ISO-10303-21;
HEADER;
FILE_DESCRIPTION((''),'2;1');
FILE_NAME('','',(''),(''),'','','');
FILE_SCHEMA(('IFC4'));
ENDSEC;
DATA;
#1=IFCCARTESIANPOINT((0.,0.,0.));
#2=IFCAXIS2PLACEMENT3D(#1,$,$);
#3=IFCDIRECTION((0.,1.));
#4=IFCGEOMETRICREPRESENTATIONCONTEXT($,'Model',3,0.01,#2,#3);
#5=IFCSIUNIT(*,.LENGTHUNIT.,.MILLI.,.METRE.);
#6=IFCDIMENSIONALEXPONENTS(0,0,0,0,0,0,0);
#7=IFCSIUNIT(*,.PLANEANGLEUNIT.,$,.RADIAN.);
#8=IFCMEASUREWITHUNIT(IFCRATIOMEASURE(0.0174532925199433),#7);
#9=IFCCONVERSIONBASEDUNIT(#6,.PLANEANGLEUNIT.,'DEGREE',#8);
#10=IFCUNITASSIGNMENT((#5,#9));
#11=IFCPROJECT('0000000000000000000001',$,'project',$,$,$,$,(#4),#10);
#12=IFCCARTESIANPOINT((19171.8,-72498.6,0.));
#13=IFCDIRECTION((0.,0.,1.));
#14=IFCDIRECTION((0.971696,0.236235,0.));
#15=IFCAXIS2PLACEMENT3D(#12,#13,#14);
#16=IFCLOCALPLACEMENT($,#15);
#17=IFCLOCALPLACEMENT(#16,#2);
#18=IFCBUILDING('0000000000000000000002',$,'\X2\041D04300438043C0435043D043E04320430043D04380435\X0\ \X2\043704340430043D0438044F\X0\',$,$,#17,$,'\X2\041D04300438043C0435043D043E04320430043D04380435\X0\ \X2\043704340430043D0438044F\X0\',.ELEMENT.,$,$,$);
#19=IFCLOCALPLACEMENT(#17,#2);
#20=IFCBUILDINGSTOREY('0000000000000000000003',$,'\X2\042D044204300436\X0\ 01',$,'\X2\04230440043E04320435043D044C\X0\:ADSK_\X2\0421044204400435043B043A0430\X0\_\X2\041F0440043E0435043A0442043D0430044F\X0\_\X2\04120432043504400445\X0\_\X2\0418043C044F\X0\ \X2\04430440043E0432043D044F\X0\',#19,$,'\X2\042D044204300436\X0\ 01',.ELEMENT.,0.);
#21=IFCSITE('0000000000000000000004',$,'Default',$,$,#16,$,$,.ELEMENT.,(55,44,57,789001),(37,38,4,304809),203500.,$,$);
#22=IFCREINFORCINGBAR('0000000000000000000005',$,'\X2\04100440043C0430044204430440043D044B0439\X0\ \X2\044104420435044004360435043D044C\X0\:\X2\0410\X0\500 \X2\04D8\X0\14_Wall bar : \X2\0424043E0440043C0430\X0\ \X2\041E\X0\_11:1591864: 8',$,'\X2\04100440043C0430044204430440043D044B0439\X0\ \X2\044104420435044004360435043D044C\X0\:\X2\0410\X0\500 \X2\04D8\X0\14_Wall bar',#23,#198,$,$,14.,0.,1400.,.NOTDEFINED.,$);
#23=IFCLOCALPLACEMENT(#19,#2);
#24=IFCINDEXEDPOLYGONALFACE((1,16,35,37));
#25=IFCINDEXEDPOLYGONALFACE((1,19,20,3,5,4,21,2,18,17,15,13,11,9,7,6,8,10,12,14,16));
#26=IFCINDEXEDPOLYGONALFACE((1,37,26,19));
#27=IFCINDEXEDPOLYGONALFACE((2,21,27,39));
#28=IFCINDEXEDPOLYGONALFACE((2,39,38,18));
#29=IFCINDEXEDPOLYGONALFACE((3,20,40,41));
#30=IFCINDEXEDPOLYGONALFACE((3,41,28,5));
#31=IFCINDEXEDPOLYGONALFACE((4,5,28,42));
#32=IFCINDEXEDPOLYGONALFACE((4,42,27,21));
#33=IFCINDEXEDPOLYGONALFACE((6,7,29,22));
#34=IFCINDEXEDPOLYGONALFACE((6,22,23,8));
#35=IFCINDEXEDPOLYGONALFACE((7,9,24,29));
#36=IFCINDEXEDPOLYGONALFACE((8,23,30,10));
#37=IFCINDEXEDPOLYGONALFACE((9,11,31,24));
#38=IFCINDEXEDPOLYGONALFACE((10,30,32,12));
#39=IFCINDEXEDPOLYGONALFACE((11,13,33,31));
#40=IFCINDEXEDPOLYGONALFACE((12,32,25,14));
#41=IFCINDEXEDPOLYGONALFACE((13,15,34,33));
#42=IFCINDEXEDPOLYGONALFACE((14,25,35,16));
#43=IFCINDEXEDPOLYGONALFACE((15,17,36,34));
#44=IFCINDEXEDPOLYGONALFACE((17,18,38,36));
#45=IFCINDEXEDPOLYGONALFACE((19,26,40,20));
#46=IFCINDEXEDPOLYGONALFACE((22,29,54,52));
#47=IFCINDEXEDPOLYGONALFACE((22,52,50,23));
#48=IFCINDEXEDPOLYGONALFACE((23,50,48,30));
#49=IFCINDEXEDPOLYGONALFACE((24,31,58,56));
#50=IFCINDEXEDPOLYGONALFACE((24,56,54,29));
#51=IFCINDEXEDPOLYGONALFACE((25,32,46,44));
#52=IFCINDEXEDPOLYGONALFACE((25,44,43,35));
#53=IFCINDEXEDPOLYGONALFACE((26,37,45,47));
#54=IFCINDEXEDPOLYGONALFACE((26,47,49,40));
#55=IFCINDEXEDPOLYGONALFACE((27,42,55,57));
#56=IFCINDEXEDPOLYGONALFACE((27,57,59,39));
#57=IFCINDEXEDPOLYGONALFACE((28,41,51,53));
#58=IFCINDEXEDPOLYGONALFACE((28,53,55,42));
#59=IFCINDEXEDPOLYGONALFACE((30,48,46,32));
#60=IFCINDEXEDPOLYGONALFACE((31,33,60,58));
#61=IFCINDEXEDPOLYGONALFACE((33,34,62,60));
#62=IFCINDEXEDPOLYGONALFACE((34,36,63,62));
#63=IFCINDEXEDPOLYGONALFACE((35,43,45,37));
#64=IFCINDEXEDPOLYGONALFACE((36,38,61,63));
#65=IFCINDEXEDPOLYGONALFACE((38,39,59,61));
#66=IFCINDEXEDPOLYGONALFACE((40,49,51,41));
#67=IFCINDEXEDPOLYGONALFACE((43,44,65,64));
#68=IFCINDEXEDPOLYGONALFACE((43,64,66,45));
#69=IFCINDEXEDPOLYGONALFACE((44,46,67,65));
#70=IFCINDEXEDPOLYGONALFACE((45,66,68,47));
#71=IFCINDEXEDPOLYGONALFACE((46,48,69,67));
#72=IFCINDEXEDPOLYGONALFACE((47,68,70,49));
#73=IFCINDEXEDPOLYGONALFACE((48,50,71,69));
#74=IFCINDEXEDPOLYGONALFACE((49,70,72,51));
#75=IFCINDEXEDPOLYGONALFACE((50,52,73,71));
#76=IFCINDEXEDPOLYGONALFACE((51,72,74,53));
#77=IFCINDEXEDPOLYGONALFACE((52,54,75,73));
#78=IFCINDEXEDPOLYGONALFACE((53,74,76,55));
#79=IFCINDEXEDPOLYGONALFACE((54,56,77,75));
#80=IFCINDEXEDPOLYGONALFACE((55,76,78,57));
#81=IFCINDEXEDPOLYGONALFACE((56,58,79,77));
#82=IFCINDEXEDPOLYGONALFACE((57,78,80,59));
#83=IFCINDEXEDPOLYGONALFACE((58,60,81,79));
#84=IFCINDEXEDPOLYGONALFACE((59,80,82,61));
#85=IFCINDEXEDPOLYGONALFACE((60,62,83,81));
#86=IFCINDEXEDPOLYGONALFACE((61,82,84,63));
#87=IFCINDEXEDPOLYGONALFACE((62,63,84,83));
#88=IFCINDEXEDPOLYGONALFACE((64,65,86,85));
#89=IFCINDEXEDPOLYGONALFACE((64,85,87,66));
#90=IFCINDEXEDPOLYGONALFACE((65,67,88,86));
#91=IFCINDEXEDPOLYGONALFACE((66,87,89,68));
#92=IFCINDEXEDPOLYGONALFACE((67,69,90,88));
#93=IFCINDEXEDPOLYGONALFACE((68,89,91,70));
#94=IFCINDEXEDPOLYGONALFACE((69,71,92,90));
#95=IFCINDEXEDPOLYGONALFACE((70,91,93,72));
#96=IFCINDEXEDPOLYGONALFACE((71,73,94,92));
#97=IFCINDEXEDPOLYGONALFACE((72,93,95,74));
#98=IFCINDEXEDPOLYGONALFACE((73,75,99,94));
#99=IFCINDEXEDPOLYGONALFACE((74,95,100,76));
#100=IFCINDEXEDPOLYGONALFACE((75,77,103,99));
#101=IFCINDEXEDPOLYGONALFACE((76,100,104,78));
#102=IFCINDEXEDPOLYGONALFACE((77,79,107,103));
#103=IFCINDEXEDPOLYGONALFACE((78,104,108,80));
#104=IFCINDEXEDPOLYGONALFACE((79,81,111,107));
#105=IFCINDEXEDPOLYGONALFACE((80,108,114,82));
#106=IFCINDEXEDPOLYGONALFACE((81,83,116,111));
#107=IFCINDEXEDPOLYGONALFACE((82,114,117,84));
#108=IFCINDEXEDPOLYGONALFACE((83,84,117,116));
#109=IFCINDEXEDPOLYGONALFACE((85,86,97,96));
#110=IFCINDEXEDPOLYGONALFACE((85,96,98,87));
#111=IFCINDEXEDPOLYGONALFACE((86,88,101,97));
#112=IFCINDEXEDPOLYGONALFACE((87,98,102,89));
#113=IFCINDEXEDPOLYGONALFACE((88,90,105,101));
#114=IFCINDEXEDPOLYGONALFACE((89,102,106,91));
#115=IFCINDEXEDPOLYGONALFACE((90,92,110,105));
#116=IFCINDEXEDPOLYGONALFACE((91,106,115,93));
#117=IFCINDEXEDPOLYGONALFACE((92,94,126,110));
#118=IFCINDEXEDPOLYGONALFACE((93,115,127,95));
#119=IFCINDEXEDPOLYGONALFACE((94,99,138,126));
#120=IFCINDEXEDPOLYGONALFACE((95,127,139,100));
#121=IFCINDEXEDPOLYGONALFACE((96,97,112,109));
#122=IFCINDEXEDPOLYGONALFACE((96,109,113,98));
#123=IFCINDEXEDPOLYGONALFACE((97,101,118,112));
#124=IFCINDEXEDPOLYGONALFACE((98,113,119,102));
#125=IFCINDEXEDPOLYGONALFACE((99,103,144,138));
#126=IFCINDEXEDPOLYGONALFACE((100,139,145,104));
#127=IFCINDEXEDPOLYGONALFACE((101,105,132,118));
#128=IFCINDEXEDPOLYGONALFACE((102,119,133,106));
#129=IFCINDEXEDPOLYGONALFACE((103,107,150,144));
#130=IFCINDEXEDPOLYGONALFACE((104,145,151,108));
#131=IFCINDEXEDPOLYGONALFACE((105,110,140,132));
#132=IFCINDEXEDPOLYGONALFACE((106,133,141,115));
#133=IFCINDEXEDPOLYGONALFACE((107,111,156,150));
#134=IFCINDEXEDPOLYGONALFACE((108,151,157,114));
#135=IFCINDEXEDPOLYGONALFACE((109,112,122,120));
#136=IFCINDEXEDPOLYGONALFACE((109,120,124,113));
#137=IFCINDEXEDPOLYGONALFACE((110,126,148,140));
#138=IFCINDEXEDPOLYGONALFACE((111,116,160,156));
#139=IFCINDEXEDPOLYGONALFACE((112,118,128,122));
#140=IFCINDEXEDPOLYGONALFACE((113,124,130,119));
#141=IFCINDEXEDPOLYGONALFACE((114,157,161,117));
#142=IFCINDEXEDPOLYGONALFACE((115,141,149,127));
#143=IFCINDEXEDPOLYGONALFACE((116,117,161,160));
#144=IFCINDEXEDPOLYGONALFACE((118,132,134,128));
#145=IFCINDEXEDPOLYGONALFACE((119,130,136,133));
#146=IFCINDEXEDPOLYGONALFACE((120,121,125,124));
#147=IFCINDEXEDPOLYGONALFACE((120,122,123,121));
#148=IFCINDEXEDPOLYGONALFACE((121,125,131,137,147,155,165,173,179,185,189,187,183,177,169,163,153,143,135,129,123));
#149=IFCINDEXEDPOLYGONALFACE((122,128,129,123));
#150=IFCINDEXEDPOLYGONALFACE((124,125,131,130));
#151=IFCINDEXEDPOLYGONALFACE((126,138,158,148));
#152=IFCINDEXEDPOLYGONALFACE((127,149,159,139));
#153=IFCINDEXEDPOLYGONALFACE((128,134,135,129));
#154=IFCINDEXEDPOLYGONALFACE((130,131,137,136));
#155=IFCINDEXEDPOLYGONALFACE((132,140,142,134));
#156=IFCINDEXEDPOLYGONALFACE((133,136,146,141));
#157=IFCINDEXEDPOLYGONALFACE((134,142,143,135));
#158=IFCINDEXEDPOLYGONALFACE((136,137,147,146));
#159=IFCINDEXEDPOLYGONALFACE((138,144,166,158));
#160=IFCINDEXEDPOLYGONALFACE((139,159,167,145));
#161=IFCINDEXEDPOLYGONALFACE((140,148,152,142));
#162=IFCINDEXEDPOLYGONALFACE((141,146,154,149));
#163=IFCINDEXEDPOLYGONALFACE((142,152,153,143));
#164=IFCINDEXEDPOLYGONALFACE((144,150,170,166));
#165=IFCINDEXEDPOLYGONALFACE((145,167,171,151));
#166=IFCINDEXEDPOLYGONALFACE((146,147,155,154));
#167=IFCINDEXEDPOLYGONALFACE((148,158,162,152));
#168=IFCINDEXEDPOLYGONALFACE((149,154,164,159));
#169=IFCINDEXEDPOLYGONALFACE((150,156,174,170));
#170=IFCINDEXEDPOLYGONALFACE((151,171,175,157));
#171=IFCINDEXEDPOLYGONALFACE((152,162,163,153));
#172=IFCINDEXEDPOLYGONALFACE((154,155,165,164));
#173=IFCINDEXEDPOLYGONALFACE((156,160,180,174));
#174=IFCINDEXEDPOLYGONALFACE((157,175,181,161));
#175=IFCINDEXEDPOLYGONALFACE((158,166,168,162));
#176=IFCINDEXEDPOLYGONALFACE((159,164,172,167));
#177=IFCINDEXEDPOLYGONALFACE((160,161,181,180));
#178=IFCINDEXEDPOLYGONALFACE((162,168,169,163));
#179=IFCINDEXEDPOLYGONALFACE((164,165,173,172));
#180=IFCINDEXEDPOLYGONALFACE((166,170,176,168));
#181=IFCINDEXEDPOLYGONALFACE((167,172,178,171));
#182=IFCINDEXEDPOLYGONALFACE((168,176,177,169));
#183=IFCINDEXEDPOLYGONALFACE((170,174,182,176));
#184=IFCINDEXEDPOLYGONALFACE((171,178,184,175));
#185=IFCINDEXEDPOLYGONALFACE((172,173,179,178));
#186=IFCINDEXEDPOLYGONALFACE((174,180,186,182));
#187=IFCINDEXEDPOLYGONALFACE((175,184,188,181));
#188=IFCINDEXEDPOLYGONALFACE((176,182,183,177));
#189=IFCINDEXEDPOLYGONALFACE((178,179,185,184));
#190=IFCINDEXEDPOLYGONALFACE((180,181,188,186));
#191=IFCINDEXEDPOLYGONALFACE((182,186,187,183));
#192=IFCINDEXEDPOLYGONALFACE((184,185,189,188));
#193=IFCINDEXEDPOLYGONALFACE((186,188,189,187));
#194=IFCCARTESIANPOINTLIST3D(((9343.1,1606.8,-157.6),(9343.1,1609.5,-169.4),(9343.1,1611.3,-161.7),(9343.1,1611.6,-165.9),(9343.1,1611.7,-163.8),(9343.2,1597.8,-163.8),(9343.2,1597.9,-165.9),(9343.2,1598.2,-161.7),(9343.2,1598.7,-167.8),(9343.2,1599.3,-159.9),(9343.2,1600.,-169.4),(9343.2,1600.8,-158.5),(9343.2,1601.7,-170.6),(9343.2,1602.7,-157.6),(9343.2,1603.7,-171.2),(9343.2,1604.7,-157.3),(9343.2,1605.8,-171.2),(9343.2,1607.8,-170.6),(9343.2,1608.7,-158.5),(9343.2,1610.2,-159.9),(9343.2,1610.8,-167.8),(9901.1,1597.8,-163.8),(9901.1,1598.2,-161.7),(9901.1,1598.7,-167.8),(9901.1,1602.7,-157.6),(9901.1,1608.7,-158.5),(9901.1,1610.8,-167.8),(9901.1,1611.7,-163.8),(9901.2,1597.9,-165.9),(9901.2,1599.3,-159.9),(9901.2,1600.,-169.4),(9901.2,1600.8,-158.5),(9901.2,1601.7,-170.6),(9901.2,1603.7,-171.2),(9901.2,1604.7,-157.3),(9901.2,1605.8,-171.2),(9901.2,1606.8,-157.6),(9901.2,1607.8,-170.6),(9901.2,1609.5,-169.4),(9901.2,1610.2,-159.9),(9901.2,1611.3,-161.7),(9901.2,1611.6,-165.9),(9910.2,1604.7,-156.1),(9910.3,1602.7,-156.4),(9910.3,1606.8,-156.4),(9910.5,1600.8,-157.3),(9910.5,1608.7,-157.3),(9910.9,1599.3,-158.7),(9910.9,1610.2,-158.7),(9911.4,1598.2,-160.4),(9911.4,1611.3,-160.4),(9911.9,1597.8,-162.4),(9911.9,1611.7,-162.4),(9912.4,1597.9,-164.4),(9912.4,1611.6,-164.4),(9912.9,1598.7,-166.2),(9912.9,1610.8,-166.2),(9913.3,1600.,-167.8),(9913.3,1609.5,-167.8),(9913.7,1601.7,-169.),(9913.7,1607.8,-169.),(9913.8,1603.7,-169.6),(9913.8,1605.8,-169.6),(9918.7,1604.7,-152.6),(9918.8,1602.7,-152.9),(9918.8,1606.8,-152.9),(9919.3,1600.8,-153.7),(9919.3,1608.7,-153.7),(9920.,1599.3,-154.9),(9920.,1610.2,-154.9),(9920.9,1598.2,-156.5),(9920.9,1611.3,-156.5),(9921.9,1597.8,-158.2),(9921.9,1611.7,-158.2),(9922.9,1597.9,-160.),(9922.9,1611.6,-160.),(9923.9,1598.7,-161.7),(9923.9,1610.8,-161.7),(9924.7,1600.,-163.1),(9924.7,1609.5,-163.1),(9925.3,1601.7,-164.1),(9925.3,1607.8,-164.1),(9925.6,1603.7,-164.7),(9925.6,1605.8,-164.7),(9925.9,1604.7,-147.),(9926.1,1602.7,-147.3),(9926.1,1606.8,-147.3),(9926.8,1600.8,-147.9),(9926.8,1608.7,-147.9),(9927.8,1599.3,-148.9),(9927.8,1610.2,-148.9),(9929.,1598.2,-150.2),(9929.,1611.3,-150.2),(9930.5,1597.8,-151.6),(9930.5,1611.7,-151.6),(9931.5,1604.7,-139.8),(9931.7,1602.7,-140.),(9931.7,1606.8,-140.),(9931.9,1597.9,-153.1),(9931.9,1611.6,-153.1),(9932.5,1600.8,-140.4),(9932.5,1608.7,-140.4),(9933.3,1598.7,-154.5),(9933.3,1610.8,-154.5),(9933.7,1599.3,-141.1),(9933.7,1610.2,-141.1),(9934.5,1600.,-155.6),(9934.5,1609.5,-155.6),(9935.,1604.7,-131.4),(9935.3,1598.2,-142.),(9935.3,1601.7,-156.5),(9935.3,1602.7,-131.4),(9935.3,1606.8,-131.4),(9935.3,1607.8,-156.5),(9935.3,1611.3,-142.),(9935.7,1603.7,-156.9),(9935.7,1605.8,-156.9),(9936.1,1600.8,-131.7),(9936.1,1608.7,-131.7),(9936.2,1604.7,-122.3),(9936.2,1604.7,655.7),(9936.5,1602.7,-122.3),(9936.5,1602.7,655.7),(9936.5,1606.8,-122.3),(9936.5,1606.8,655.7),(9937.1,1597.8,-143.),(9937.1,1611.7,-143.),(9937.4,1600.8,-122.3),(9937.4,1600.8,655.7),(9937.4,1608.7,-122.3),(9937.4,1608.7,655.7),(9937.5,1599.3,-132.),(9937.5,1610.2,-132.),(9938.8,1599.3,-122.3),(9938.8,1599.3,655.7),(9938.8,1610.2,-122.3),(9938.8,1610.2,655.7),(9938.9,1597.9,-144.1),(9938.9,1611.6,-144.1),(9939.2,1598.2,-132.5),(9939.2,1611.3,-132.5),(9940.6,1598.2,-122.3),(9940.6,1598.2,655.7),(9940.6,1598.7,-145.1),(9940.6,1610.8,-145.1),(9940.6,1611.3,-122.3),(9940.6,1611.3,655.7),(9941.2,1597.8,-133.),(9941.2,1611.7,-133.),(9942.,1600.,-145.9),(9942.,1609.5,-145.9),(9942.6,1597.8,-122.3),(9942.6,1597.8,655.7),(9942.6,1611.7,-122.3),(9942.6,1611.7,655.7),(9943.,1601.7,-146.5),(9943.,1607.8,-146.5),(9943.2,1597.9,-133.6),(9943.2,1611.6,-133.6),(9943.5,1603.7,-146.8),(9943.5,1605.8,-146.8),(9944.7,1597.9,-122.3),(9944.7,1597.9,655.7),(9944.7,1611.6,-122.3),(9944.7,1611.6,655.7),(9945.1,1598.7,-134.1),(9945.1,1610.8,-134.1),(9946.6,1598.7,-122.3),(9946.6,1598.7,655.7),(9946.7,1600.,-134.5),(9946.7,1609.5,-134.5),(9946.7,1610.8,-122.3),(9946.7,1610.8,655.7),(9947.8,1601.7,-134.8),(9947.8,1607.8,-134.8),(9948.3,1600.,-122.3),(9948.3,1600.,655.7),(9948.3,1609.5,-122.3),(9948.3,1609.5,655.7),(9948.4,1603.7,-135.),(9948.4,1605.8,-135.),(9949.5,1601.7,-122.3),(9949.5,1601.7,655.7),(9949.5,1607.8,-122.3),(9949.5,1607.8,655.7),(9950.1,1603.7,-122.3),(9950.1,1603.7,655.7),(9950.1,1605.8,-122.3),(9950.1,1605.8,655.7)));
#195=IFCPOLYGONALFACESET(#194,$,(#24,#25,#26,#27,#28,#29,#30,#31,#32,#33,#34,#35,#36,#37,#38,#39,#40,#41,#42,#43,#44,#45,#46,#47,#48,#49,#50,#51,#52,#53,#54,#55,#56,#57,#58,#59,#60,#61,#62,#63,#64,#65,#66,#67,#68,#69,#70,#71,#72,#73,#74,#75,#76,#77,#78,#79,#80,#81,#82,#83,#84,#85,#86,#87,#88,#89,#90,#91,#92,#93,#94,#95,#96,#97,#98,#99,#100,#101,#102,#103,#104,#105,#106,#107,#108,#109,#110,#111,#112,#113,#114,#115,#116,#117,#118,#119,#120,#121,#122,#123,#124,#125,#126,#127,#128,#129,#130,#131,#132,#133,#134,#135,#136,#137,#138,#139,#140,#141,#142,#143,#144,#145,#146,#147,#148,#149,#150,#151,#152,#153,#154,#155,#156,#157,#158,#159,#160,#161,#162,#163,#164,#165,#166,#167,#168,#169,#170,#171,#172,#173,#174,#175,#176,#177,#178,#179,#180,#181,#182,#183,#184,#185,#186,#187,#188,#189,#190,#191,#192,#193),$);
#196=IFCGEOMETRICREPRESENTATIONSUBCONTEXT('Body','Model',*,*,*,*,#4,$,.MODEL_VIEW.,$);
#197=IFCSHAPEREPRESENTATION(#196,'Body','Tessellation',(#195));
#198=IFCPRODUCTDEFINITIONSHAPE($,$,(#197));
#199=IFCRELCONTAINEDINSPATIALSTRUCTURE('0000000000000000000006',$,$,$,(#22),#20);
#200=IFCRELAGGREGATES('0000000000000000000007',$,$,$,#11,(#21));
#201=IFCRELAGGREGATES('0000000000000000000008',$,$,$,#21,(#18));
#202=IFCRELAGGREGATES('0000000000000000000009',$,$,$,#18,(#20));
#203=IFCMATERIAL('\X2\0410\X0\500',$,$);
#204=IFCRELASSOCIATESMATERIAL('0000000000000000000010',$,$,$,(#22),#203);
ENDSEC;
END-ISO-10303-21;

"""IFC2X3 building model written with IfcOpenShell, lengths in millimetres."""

from ifc_helpers import new_model, entity, si_unit, converted_unit, direction, frame, origin, place, context, subcontext, project, spatial, material, element, save


model = new_model("IFC2X3")

# Units and contexts
model_context = context("Model", 3, precision=0.01, world=origin(), true_north=direction((0.0, 1.0)))
body_context = subcontext(model_context, "Body", "Model", "MODEL_VIEW")
ifc_project = project(units=[si_unit("LENGTHUNIT", "METRE", prefix="MILLI"), converted_unit("PLANEANGLEUNIT", "DEGREE", entity("IfcRatioMeasure", 0.0174532925199433), si_unit("PLANEANGLEUNIT", "RADIAN"), dimensions=[0, 0, 0, 0, 0, 0, 0])], contexts=[model_context])

# Site, building, storey
site_placement = place(None, frame((19171.8, -72498.6, 0.0), z_axis=(0.0, 0.0, 1.0), x_axis=(0.971696, 0.236235, 0.0)))
site = spatial("IfcSite", under=ifc_project, at=site_placement, Name="Default", CompositionType="ELEMENT", RefLatitude=(55, 44, 57, 789001), RefLongitude=(37, 38, 4, 304809), RefElevation=203500.0)
building_placement = place(site_placement, origin())
building = spatial("IfcBuilding", under=site, at=building_placement, Name="Наименование здания", LongName="Наименование здания", CompositionType="ELEMENT")
storey_placement = place(building_placement, origin())
storey = spatial("IfcBuildingStorey", under=building, at=storey_placement, Name="Этаж 01", ObjectType="Уровень:ADSK_Стрелка_Проектная_Вверх_Имя уровня", LongName="Этаж 01", CompositionType="ELEMENT", Elevation=0.0)

# Reinforcing bar
ifc_material = material(Name="А500")
placement = place(storey_placement, origin())
element("IfcReinforcingBar", 1, at=placement, inside=storey, material=ifc_material, Name="Арматурный стержень:А500 Ә14_Wall bar : Форма О_11:1591864: 8", ObjectType="Арматурный стержень:А500 Ә14_Wall bar", BarLength=1400.0, BarRole="NOTDEFINED", CrossSectionArea=0.0, NominalDiameter=14.0, context=body_context, shape_type="AdvancedSweptSolid", body=[
    entity("IfcSweptDiskSolid", entity("IfcCompositeCurve", [entity("IfcCompositeCurveSegment", "CONTINUOUS", True, entity("IfcPolyline", [entity("IfcCartesianPoint", [9943.1, 1604.7, 655.7]), entity("IfcCartesianPoint", [9943.1, 1604.7, -122.3])])), entity("IfcCompositeCurveSegment", "CONTINUOUS", True, entity("IfcTrimmedCurve", entity("IfcCircle", entity("IfcAxis2Placement3D", entity("IfcCartesianPoint", [9901.1, 1604.7, -122.3]), entity("IfcDirection", [0.0, 1.0, 0.0]), entity("IfcDirection", [0.0, 0.0, -1.0])), 42.0), [entity("IfcParameterValue", 270.0)], [entity("IfcParameterValue", 360.0)], True, "PARAMETER")), entity("IfcCompositeCurveSegment", "CONTINUOUS", True, entity("IfcPolyline", [entity("IfcCartesianPoint", [9901.1, 1604.7, -164.3]), entity("IfcCartesianPoint", [9343.1, 1604.7, -164.3])]))], False), 7.0, None, 0.0, 92.0),
])

save(model, "model.ifc")
